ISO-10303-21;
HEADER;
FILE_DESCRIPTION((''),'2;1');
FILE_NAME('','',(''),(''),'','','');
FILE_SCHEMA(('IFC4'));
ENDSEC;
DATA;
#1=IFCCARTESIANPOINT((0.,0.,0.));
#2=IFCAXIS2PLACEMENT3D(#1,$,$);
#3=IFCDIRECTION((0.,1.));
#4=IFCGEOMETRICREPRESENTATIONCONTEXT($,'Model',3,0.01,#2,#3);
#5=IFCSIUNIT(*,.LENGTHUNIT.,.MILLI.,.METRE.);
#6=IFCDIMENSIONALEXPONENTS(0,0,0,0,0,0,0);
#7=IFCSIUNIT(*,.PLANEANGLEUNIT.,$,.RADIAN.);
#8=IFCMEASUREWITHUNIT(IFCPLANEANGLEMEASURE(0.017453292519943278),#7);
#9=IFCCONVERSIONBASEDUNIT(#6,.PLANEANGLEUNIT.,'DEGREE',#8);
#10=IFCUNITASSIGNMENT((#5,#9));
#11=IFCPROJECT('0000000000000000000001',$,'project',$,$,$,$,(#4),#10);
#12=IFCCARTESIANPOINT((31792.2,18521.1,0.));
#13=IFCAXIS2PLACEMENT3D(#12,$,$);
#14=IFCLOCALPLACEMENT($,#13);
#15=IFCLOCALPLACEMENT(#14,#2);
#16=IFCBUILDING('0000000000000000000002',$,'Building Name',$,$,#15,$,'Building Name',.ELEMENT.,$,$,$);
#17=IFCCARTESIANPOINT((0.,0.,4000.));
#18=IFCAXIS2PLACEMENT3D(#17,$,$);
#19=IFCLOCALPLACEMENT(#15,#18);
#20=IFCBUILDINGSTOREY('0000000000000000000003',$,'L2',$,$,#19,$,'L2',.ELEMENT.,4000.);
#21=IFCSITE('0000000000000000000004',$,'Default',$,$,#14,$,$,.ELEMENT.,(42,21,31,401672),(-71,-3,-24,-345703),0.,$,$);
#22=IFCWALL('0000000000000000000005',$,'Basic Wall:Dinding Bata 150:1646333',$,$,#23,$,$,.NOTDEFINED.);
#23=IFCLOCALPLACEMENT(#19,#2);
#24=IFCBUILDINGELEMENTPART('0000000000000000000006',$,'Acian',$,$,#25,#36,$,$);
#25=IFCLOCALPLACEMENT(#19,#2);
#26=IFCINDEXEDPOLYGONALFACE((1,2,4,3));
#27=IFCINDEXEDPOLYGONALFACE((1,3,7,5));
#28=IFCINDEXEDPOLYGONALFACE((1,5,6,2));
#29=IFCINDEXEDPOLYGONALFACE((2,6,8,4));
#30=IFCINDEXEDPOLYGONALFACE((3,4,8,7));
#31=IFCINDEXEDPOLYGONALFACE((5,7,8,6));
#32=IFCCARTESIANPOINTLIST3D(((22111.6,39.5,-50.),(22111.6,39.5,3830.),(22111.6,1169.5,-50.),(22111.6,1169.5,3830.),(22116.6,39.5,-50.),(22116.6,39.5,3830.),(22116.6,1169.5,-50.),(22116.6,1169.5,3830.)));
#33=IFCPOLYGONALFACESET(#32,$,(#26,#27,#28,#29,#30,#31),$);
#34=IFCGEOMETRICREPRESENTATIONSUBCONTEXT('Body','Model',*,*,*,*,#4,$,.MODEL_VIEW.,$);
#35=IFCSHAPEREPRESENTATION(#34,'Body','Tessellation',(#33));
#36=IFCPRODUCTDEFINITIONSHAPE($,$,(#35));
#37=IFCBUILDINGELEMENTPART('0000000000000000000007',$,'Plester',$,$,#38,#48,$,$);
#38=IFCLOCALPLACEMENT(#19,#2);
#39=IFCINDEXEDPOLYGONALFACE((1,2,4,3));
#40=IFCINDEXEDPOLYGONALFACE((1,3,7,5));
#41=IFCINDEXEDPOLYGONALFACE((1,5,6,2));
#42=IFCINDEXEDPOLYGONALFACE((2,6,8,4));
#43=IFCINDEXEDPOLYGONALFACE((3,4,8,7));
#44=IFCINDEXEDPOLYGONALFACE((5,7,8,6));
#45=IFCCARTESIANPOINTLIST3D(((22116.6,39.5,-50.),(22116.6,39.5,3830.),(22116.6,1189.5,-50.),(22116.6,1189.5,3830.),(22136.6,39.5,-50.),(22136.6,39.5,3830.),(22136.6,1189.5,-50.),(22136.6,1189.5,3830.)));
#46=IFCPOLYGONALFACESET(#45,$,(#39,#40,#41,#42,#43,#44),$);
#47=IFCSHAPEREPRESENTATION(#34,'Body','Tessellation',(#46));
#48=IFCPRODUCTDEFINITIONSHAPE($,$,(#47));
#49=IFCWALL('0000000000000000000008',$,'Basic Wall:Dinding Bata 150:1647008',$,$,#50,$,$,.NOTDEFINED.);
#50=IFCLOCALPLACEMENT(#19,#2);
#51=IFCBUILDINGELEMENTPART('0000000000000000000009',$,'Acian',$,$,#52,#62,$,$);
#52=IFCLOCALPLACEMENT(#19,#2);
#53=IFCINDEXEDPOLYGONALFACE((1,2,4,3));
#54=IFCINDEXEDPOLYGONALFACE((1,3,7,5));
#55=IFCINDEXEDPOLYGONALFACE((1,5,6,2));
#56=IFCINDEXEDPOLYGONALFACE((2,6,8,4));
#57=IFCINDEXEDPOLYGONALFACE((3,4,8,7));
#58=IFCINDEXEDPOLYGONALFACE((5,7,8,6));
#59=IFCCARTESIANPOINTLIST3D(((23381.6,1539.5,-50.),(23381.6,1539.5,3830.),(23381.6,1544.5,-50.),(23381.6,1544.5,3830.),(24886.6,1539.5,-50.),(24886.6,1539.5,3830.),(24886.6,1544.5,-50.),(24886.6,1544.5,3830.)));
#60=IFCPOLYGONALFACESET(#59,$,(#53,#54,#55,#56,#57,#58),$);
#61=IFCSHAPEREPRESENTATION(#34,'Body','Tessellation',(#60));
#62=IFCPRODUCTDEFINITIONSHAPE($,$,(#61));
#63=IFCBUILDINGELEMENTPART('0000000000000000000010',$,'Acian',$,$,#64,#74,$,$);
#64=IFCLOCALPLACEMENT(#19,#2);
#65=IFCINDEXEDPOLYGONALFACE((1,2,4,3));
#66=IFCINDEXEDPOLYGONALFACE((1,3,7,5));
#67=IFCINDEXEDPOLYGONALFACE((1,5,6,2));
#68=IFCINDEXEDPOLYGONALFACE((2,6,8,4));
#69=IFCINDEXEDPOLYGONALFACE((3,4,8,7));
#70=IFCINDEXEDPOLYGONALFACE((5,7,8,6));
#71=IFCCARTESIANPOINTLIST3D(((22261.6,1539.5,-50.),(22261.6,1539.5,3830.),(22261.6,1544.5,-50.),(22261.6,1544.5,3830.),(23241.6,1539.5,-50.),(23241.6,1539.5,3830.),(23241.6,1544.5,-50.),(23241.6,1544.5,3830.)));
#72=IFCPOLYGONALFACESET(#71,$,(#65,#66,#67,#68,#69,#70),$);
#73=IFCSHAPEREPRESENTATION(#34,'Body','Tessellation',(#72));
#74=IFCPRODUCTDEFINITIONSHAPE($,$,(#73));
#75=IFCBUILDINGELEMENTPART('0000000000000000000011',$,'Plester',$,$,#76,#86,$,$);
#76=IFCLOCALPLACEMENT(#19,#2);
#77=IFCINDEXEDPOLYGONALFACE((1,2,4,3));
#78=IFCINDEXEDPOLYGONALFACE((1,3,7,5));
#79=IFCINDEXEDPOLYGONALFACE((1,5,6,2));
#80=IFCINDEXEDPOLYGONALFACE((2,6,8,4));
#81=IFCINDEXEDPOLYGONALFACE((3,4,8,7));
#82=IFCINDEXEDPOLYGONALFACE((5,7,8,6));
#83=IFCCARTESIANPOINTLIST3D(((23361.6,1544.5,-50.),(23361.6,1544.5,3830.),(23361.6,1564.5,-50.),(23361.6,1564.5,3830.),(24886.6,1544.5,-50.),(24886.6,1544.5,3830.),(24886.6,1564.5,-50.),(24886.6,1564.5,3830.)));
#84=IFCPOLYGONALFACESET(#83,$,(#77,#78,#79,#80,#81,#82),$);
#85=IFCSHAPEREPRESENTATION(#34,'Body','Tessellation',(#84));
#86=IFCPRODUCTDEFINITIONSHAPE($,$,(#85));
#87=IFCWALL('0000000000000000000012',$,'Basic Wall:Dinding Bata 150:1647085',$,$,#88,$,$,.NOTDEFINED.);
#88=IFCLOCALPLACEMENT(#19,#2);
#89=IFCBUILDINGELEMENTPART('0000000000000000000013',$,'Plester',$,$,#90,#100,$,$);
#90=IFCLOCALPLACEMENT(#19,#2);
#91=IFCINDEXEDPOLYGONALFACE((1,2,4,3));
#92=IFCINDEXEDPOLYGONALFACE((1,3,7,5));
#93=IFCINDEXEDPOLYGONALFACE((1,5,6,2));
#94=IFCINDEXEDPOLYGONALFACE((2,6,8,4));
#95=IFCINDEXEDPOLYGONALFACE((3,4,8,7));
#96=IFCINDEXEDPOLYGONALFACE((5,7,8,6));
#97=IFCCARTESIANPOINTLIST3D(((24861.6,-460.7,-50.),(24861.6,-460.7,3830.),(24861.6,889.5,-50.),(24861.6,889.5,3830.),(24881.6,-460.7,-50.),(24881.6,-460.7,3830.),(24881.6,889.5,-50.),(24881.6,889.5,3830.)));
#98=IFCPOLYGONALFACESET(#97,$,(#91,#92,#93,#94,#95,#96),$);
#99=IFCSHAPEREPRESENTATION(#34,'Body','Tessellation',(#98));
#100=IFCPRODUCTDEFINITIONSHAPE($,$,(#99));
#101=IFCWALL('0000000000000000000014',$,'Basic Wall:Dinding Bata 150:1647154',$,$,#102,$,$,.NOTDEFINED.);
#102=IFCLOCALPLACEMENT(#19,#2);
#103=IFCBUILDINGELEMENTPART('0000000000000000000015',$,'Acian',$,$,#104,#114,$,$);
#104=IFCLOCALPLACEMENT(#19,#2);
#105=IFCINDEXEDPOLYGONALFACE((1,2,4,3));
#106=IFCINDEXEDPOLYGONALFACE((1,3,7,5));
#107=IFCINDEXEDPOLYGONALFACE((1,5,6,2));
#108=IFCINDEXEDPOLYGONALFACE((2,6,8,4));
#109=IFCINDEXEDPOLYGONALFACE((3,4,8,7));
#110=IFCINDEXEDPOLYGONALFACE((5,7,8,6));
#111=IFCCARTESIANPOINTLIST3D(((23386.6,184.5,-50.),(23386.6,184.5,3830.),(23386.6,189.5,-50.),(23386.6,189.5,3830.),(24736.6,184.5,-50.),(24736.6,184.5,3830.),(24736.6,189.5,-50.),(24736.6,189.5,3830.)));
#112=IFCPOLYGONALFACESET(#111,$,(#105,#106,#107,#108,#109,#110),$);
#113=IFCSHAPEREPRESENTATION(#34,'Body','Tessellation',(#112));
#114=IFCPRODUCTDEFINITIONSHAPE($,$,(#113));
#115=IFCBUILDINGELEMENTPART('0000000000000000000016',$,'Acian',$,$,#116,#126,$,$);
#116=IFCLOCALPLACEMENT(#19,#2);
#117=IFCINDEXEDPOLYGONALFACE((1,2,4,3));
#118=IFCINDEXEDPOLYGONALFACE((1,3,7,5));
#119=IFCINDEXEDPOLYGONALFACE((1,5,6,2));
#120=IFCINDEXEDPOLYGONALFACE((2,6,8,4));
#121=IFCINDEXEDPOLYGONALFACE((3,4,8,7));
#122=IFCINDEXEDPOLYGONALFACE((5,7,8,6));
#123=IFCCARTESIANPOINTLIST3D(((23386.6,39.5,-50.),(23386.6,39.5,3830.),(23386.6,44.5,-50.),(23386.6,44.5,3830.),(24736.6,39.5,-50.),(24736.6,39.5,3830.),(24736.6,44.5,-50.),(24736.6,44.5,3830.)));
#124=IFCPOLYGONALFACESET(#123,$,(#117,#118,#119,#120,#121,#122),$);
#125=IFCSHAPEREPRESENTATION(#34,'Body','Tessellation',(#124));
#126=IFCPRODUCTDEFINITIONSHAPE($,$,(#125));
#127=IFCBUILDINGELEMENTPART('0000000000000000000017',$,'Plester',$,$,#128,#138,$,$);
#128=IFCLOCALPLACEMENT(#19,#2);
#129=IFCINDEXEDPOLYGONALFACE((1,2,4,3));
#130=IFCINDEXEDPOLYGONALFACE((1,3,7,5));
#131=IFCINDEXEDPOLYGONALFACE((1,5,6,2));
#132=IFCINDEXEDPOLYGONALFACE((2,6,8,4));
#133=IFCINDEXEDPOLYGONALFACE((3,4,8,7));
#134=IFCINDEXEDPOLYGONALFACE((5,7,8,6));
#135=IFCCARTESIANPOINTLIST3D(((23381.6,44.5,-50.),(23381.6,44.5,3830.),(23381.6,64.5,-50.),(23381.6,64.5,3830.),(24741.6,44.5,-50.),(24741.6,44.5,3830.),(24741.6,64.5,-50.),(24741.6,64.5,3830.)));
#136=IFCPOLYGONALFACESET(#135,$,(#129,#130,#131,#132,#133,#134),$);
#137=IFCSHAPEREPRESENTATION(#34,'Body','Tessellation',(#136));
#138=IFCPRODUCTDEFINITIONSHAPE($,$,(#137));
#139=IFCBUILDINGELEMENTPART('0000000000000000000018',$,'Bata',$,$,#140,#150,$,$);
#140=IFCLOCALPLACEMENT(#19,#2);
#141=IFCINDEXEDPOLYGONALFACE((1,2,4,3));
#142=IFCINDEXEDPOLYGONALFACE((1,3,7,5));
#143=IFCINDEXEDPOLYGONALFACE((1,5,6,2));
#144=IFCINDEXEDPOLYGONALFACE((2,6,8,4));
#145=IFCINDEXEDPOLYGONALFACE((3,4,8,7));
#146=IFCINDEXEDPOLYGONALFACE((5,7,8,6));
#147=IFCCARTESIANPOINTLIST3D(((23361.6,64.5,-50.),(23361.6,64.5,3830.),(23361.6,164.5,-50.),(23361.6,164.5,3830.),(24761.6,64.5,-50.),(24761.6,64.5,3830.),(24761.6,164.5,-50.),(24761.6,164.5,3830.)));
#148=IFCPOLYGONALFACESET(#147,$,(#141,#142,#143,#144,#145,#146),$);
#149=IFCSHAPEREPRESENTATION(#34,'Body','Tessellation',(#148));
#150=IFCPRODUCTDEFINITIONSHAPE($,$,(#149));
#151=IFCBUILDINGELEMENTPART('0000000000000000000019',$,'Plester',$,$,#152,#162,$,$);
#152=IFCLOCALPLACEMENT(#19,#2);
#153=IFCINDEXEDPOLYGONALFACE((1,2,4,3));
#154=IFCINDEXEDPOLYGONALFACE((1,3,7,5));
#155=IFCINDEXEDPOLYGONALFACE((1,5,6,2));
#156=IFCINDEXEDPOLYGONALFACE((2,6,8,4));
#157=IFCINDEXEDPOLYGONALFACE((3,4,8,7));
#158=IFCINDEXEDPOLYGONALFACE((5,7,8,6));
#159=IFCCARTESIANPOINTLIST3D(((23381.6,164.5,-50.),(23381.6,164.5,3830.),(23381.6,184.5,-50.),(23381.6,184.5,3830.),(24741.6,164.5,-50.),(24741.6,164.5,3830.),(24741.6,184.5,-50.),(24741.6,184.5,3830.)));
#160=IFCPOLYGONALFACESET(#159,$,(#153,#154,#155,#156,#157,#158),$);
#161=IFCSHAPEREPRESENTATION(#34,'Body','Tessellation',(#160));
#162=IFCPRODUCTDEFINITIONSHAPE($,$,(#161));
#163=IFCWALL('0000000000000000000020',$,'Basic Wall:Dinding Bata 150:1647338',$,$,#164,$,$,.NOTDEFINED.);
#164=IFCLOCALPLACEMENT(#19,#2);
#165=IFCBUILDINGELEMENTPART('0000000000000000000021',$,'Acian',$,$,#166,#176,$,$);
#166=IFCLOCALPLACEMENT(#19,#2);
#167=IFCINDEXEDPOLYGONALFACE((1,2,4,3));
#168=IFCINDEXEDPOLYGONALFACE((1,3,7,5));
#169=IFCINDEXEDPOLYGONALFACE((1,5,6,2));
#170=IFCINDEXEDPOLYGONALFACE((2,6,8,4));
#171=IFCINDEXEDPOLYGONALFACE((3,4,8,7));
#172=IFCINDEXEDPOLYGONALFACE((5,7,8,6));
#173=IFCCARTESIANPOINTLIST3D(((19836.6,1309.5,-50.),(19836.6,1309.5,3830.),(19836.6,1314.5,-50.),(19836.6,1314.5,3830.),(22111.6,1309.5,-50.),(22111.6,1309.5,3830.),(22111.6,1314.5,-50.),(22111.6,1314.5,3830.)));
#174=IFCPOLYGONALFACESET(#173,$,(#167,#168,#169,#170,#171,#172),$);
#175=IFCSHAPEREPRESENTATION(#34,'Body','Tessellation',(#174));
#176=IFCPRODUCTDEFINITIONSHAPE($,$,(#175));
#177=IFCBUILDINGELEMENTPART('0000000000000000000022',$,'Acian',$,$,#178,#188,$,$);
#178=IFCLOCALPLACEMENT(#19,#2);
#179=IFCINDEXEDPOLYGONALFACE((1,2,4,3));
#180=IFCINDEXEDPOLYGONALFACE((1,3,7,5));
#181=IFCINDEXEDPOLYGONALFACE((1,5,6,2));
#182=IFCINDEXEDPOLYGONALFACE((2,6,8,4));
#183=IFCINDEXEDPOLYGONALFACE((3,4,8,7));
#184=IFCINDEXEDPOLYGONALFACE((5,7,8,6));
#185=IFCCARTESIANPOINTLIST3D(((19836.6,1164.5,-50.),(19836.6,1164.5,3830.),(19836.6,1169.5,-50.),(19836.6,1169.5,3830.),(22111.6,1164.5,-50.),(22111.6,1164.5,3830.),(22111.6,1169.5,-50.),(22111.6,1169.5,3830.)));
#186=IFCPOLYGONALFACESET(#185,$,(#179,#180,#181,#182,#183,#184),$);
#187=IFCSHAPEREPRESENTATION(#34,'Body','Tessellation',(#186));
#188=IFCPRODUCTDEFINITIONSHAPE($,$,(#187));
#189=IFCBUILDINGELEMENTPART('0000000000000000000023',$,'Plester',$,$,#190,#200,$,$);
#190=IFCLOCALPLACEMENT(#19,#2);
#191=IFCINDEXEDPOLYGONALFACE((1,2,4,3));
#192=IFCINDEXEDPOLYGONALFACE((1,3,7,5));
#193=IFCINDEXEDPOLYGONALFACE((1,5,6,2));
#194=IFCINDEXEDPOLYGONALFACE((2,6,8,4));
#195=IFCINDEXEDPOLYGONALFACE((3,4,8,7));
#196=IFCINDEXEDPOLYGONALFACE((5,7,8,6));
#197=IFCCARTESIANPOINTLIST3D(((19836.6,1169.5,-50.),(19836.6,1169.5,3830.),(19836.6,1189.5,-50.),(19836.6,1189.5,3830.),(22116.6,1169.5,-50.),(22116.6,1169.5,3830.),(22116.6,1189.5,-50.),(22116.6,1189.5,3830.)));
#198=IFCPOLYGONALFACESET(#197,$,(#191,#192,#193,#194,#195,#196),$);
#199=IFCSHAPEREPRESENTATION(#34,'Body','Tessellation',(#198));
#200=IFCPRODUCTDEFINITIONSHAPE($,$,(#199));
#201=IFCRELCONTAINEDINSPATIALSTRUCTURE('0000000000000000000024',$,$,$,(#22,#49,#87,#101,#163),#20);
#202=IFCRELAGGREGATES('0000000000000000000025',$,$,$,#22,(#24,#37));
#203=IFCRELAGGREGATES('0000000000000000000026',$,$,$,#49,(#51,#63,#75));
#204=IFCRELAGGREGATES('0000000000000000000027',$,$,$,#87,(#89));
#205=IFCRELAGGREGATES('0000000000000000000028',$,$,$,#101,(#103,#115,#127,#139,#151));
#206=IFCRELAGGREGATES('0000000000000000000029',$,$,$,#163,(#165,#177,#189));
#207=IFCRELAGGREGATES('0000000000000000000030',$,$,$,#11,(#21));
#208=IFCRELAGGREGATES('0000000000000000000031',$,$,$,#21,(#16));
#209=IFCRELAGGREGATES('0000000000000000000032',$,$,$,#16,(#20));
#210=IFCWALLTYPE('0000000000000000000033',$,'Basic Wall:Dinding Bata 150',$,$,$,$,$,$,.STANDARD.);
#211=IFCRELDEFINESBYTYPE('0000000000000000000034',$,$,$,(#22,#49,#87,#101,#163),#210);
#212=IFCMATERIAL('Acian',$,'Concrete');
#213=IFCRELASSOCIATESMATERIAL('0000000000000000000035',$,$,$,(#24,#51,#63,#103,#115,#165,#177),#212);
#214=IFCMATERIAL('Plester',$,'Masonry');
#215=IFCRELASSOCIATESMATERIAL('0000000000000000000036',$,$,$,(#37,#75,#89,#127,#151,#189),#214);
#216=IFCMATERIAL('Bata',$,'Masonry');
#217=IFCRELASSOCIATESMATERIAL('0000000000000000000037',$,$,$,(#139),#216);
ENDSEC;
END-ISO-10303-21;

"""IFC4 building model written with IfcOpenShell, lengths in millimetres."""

from ifc_helpers import new_model, entity, si_unit, converted_unit, direction, frame, origin, place, context, subcontext, project, spatial, indexed_curve, outline, extrude, material, type_object, element, aggregate, save


model = new_model("IFC4")

# Units and contexts
model_context = context("Model", 3, precision=0.01, world=origin(), true_north=direction((0.0, 1.0)))
body_context = subcontext(model_context, "Body", "Model", "MODEL_VIEW")
ifc_project = project(units=[si_unit("LENGTHUNIT", "METRE", prefix="MILLI"), converted_unit("PLANEANGLEUNIT", "DEGREE", entity("IfcPlaneAngleMeasure", 0.017453292519943278), si_unit("PLANEANGLEUNIT", "RADIAN"), dimensions=[0, 0, 0, 0, 0, 0, 0])], contexts=[model_context])

# Site, building, storey
site_placement = place(None, frame((31792.2, 18521.1, 0.0)))
site = spatial("IfcSite", under=ifc_project, at=site_placement, Name="Default", CompositionType="ELEMENT", RefLatitude=(42, 21, 31, 401672), RefLongitude=(-71, -3, -24, -345703), RefElevation=0.0)
building_placement = place(site_placement, origin())
building = spatial("IfcBuilding", under=site, at=building_placement, Name="Building Name", LongName="Building Name", CompositionType="ELEMENT")
storey_placement = place(building_placement, frame((0.0, 0.0, 4000.0)))
storey = spatial("IfcBuildingStorey", under=building, at=storey_placement, Name="L2", LongName="L2", CompositionType="ELEMENT", Elevation=4000.0)

# Walls, building element parts
wall_type_1 = type_object("IfcWallType", Name="Basic Wall:Dinding Bata 150", PredefinedType="STANDARD")
wall_1_placement = place(storey_placement, frame((22186.6, 1689.5, -50.0), z_axis=(0.0, 0.0, 1.0), x_axis=(0.0, -1.0, 0.0)))
wall_1 = element("IfcWall", 1, at=wall_1_placement, inside=storey, type_object=wall_type_1, Name="Basic Wall:Dinding Bata 150:1646333", PredefinedType="NOTDEFINED")
ifc_material_1 = material(Name="Acian", Category="Concrete")
building_element_part_1_placement = place(wall_1_placement, origin())
building_element_part_1 = element("IfcBuildingElementPart", 2, at=building_element_part_1_placement, material=ifc_material_1, Name="Acian", context=body_context, shape_type="SweptSolid", body=[
    extrude(outline(indexed_curve([(-565.0, -2.5), (565.0, -2.5), (565.0, 2.5), (-565.0, 2.5), (-565.0, -2.5)], self_intersect=False)), frame((1085.0, -72.5, 0.0)), (0.0, 0.0, 1.0), 3880.0),
])
ifc_material_2 = material(Name="Plester", Category="Masonry")
building_element_part_2_placement = place(wall_1_placement, origin())
building_element_part_2 = element("IfcBuildingElementPart", 3, at=building_element_part_2_placement, material=ifc_material_2, Name="Plester", context=body_context, shape_type="SweptSolid", body=[
    extrude(outline(indexed_curve([(-575.0, -10.0), (575.0, -10.0), (575.0, 10.0), (-575.0, 10.0), (-575.0, -10.0)], self_intersect=False)), frame((1075.0, -60.0, 0.0)), (0.0, 0.0, 1.0), 3880.0),
])
aggregate(wall_1, [building_element_part_1, building_element_part_2])
wall_2_placement = place(storey_placement, frame((22261.6, 1614.5, -50.0)))
wall_2 = element("IfcWall", 4, at=wall_2_placement, inside=storey, type_object=wall_type_1, Name="Basic Wall:Dinding Bata 150:1647008", PredefinedType="NOTDEFINED")
building_element_part_3_placement = place(wall_2_placement, origin())
building_element_part_3 = element("IfcBuildingElementPart", 5, at=building_element_part_3_placement, material=ifc_material_1, Name="Acian", context=body_context, shape_type="SweptSolid", body=[
    extrude(outline(indexed_curve([(-2.5, -752.5), (2.5, -752.5), (2.5, 752.5), (-2.5, 752.5), (-2.5, -752.5)], self_intersect=False)), frame((1872.5, -72.5, 0.0), z_axis=(0.0, 0.0, 1.0), x_axis=(0.0, -1.0, 0.0)), (0.0, 0.0, 1.0), 3880.0),
])
building_element_part_4_placement = place(wall_2_placement, origin())
building_element_part_4 = element("IfcBuildingElementPart", 6, at=building_element_part_4_placement, material=ifc_material_1, Name="Acian", context=body_context, shape_type="SweptSolid", body=[
    extrude(outline(indexed_curve([(-2.5, -490.0), (2.5, -490.0), (2.5, 490.0), (-2.5, 490.0), (-2.5, -490.0)], self_intersect=False)), frame((490.0, -72.5, 0.0), z_axis=(0.0, 0.0, 1.0), x_axis=(0.0, -1.0, 0.0)), (0.0, 0.0, 1.0), 3880.0),
])
building_element_part_5_placement = place(wall_2_placement, origin())
building_element_part_5 = element("IfcBuildingElementPart", 7, at=building_element_part_5_placement, material=ifc_material_2, Name="Plester", context=body_context, shape_type="SweptSolid", body=[
    extrude(outline(indexed_curve([(-10.0, -762.5), (10.0, -762.5), (10.0, 762.5), (-10.0, 762.5), (-10.0, -762.5)], self_intersect=False)), frame((1862.5, -60.0, 0.0), z_axis=(0.0, 0.0, 1.0), x_axis=(0.0, -1.0, 0.0)), (0.0, 0.0, 1.0), 3880.0),
])
aggregate(wall_2, [building_element_part_3, building_element_part_4, building_element_part_5])

# Wall, building element part
wall_3_placement = place(storey_placement, frame((24811.6, -460.7, -50.0), z_axis=(0.0, 0.0, 1.0), x_axis=(0.0, 1.0, 0.0)))
wall_3 = element("IfcWall", 8, at=wall_3_placement, inside=storey, type_object=wall_type_1, Name="Basic Wall:Dinding Bata 150:1647085", PredefinedType="NOTDEFINED")
building_element_part_6_placement = place(wall_3_placement, origin())
building_element_part_6 = element("IfcBuildingElementPart", 9, at=building_element_part_6_placement, material=ifc_material_2, Name="Plester", context=body_context, shape_type="SweptSolid", body=[
    extrude(outline(indexed_curve([(-675.1, -10.0), (675.1, -10.0), (675.1, 10.0), (-675.1, 10.0), (-675.1, -10.0)], self_intersect=False)), frame((675.1, -60.0, 0.0), z_axis=(0.0, 0.0, 1.0), x_axis=(-1.0, 0.0, 0.0)), (0.0, 0.0, 1.0), 3880.0),
])
aggregate(wall_3, [building_element_part_6])

# Walls, building element parts
wall_4_placement = place(storey_placement, frame((24736.6, 114.5, -50.0), z_axis=(0.0, 0.0, 1.0), x_axis=(-1.0, 0.0, 0.0)))
wall_4 = element("IfcWall", 10, at=wall_4_placement, inside=storey, type_object=wall_type_1, Name="Basic Wall:Dinding Bata 150:1647154", PredefinedType="NOTDEFINED")
building_element_part_7_placement = place(wall_4_placement, origin())
building_element_part_7 = element("IfcBuildingElementPart", 11, at=building_element_part_7_placement, material=ifc_material_1, Name="Acian", context=body_context, shape_type="SweptSolid", body=[
    extrude(outline(indexed_curve([(-2.5, -675.0), (2.5, -675.0), (2.5, 675.0), (-2.5, 675.0), (-2.5, -675.0)], self_intersect=False)), frame((675.0, -72.5, 0.0), z_axis=(0.0, 0.0, 1.0), x_axis=(0.0, 1.0, 0.0)), (0.0, 0.0, 1.0), 3880.0),
])
building_element_part_8_placement = place(wall_4_placement, origin())
building_element_part_8 = element("IfcBuildingElementPart", 12, at=building_element_part_8_placement, material=ifc_material_1, Name="Acian", context=body_context, shape_type="SweptSolid", body=[
    extrude(outline(indexed_curve([(-2.5, -675.0), (2.5, -675.0), (2.5, 675.0), (-2.5, 675.0), (-2.5, -675.0)], self_intersect=False)), frame((675.0, 72.5, 0.0), z_axis=(0.0, 0.0, 1.0), x_axis=(0.0, 1.0, 0.0)), (0.0, 0.0, 1.0), 3880.0),
])
building_element_part_9_placement = place(wall_4_placement, origin())
building_element_part_9 = element("IfcBuildingElementPart", 13, at=building_element_part_9_placement, material=ifc_material_2, Name="Plester", context=body_context, shape_type="SweptSolid", body=[
    extrude(outline(indexed_curve([(-10.0, -680.0), (10.0, -680.0), (10.0, 680.0), (-10.0, 680.0), (-10.0, -680.0)], self_intersect=False)), frame((675.0, 60.0, 0.0), z_axis=(0.0, 0.0, 1.0), x_axis=(0.0, 1.0, 0.0)), (0.0, 0.0, 1.0), 3880.0),
])
ifc_material_3 = material(Name="Bata", Category="Masonry")
building_element_part_10_placement = place(wall_4_placement, origin())
building_element_part_10 = element("IfcBuildingElementPart", 14, at=building_element_part_10_placement, material=ifc_material_3, Name="Bata", context=body_context, shape_type="SweptSolid", body=[
    extrude(outline(indexed_curve([(-50.0, -700.0), (50.0, -700.0), (50.0, 700.0), (-50.0, 700.0), (-50.0, -700.0)], self_intersect=False)), frame((675.0, 0.0, 0.0), z_axis=(0.0, 0.0, 1.0), x_axis=(0.0, 1.0, 0.0)), (0.0, 0.0, 1.0), 3880.0),
])
building_element_part_11_placement = place(wall_4_placement, origin())
building_element_part_11 = element("IfcBuildingElementPart", 15, at=building_element_part_11_placement, material=ifc_material_2, Name="Plester", context=body_context, shape_type="SweptSolid", body=[
    extrude(outline(indexed_curve([(-10.0, -680.0), (10.0, -680.0), (10.0, 680.0), (-10.0, 680.0), (-10.0, -680.0)], self_intersect=False)), frame((675.0, -60.0, 0.0), z_axis=(0.0, 0.0, 1.0), x_axis=(0.0, 1.0, 0.0)), (0.0, 0.0, 1.0), 3880.0),
])
aggregate(wall_4, [building_element_part_7, building_element_part_8, building_element_part_9, building_element_part_10, building_element_part_11])
wall_5_placement = place(storey_placement, frame((22111.6, 1239.5, -50.0), z_axis=(0.0, 0.0, 1.0), x_axis=(-1.0, 0.0, 0.0)))
wall_5 = element("IfcWall", 16, at=wall_5_placement, inside=storey, type_object=wall_type_1, Name="Basic Wall:Dinding Bata 150:1647338", PredefinedType="NOTDEFINED")
building_element_part_12_placement = place(wall_5_placement, origin())
building_element_part_12 = element("IfcBuildingElementPart", 17, at=building_element_part_12_placement, material=ifc_material_1, Name="Acian", context=body_context, shape_type="SweptSolid", body=[
    extrude(outline(indexed_curve([(-2.5, -1137.5), (2.5, -1137.5), (2.5, 1137.5), (-2.5, 1137.5), (-2.5, -1137.5)], self_intersect=False)), frame((1137.5, -72.5, 0.0), z_axis=(0.0, 0.0, 1.0), x_axis=(0.0, 1.0, 0.0)), (0.0, 0.0, 1.0), 3880.0),
])
building_element_part_13_placement = place(wall_5_placement, origin())
building_element_part_13 = element("IfcBuildingElementPart", 18, at=building_element_part_13_placement, material=ifc_material_1, Name="Acian", context=body_context, shape_type="SweptSolid", body=[
    extrude(outline(indexed_curve([(-2.5, -1137.5), (2.5, -1137.5), (2.5, 1137.5), (-2.5, 1137.5), (-2.5, -1137.5)], self_intersect=False)), frame((1137.5, 72.5, 0.0), z_axis=(0.0, 0.0, 1.0), x_axis=(0.0, 1.0, 0.0)), (0.0, 0.0, 1.0), 3880.0),
])
building_element_part_14_placement = place(wall_5_placement, origin())
building_element_part_14 = element("IfcBuildingElementPart", 19, at=building_element_part_14_placement, material=ifc_material_2, Name="Plester", context=body_context, shape_type="SweptSolid", body=[
    extrude(outline(indexed_curve([(-10.0, -1140.0), (10.0, -1140.0), (10.0, 1140.0), (-10.0, 1140.0), (-10.0, -1140.0)], self_intersect=False)), frame((1135.0, 60.0, 0.0), z_axis=(0.0, 0.0, 1.0), x_axis=(0.0, 1.0, 0.0)), (0.0, 0.0, 1.0), 3880.0),
])
aggregate(wall_5, [building_element_part_12, building_element_part_13, building_element_part_14])

save(model, "model.ifc")
